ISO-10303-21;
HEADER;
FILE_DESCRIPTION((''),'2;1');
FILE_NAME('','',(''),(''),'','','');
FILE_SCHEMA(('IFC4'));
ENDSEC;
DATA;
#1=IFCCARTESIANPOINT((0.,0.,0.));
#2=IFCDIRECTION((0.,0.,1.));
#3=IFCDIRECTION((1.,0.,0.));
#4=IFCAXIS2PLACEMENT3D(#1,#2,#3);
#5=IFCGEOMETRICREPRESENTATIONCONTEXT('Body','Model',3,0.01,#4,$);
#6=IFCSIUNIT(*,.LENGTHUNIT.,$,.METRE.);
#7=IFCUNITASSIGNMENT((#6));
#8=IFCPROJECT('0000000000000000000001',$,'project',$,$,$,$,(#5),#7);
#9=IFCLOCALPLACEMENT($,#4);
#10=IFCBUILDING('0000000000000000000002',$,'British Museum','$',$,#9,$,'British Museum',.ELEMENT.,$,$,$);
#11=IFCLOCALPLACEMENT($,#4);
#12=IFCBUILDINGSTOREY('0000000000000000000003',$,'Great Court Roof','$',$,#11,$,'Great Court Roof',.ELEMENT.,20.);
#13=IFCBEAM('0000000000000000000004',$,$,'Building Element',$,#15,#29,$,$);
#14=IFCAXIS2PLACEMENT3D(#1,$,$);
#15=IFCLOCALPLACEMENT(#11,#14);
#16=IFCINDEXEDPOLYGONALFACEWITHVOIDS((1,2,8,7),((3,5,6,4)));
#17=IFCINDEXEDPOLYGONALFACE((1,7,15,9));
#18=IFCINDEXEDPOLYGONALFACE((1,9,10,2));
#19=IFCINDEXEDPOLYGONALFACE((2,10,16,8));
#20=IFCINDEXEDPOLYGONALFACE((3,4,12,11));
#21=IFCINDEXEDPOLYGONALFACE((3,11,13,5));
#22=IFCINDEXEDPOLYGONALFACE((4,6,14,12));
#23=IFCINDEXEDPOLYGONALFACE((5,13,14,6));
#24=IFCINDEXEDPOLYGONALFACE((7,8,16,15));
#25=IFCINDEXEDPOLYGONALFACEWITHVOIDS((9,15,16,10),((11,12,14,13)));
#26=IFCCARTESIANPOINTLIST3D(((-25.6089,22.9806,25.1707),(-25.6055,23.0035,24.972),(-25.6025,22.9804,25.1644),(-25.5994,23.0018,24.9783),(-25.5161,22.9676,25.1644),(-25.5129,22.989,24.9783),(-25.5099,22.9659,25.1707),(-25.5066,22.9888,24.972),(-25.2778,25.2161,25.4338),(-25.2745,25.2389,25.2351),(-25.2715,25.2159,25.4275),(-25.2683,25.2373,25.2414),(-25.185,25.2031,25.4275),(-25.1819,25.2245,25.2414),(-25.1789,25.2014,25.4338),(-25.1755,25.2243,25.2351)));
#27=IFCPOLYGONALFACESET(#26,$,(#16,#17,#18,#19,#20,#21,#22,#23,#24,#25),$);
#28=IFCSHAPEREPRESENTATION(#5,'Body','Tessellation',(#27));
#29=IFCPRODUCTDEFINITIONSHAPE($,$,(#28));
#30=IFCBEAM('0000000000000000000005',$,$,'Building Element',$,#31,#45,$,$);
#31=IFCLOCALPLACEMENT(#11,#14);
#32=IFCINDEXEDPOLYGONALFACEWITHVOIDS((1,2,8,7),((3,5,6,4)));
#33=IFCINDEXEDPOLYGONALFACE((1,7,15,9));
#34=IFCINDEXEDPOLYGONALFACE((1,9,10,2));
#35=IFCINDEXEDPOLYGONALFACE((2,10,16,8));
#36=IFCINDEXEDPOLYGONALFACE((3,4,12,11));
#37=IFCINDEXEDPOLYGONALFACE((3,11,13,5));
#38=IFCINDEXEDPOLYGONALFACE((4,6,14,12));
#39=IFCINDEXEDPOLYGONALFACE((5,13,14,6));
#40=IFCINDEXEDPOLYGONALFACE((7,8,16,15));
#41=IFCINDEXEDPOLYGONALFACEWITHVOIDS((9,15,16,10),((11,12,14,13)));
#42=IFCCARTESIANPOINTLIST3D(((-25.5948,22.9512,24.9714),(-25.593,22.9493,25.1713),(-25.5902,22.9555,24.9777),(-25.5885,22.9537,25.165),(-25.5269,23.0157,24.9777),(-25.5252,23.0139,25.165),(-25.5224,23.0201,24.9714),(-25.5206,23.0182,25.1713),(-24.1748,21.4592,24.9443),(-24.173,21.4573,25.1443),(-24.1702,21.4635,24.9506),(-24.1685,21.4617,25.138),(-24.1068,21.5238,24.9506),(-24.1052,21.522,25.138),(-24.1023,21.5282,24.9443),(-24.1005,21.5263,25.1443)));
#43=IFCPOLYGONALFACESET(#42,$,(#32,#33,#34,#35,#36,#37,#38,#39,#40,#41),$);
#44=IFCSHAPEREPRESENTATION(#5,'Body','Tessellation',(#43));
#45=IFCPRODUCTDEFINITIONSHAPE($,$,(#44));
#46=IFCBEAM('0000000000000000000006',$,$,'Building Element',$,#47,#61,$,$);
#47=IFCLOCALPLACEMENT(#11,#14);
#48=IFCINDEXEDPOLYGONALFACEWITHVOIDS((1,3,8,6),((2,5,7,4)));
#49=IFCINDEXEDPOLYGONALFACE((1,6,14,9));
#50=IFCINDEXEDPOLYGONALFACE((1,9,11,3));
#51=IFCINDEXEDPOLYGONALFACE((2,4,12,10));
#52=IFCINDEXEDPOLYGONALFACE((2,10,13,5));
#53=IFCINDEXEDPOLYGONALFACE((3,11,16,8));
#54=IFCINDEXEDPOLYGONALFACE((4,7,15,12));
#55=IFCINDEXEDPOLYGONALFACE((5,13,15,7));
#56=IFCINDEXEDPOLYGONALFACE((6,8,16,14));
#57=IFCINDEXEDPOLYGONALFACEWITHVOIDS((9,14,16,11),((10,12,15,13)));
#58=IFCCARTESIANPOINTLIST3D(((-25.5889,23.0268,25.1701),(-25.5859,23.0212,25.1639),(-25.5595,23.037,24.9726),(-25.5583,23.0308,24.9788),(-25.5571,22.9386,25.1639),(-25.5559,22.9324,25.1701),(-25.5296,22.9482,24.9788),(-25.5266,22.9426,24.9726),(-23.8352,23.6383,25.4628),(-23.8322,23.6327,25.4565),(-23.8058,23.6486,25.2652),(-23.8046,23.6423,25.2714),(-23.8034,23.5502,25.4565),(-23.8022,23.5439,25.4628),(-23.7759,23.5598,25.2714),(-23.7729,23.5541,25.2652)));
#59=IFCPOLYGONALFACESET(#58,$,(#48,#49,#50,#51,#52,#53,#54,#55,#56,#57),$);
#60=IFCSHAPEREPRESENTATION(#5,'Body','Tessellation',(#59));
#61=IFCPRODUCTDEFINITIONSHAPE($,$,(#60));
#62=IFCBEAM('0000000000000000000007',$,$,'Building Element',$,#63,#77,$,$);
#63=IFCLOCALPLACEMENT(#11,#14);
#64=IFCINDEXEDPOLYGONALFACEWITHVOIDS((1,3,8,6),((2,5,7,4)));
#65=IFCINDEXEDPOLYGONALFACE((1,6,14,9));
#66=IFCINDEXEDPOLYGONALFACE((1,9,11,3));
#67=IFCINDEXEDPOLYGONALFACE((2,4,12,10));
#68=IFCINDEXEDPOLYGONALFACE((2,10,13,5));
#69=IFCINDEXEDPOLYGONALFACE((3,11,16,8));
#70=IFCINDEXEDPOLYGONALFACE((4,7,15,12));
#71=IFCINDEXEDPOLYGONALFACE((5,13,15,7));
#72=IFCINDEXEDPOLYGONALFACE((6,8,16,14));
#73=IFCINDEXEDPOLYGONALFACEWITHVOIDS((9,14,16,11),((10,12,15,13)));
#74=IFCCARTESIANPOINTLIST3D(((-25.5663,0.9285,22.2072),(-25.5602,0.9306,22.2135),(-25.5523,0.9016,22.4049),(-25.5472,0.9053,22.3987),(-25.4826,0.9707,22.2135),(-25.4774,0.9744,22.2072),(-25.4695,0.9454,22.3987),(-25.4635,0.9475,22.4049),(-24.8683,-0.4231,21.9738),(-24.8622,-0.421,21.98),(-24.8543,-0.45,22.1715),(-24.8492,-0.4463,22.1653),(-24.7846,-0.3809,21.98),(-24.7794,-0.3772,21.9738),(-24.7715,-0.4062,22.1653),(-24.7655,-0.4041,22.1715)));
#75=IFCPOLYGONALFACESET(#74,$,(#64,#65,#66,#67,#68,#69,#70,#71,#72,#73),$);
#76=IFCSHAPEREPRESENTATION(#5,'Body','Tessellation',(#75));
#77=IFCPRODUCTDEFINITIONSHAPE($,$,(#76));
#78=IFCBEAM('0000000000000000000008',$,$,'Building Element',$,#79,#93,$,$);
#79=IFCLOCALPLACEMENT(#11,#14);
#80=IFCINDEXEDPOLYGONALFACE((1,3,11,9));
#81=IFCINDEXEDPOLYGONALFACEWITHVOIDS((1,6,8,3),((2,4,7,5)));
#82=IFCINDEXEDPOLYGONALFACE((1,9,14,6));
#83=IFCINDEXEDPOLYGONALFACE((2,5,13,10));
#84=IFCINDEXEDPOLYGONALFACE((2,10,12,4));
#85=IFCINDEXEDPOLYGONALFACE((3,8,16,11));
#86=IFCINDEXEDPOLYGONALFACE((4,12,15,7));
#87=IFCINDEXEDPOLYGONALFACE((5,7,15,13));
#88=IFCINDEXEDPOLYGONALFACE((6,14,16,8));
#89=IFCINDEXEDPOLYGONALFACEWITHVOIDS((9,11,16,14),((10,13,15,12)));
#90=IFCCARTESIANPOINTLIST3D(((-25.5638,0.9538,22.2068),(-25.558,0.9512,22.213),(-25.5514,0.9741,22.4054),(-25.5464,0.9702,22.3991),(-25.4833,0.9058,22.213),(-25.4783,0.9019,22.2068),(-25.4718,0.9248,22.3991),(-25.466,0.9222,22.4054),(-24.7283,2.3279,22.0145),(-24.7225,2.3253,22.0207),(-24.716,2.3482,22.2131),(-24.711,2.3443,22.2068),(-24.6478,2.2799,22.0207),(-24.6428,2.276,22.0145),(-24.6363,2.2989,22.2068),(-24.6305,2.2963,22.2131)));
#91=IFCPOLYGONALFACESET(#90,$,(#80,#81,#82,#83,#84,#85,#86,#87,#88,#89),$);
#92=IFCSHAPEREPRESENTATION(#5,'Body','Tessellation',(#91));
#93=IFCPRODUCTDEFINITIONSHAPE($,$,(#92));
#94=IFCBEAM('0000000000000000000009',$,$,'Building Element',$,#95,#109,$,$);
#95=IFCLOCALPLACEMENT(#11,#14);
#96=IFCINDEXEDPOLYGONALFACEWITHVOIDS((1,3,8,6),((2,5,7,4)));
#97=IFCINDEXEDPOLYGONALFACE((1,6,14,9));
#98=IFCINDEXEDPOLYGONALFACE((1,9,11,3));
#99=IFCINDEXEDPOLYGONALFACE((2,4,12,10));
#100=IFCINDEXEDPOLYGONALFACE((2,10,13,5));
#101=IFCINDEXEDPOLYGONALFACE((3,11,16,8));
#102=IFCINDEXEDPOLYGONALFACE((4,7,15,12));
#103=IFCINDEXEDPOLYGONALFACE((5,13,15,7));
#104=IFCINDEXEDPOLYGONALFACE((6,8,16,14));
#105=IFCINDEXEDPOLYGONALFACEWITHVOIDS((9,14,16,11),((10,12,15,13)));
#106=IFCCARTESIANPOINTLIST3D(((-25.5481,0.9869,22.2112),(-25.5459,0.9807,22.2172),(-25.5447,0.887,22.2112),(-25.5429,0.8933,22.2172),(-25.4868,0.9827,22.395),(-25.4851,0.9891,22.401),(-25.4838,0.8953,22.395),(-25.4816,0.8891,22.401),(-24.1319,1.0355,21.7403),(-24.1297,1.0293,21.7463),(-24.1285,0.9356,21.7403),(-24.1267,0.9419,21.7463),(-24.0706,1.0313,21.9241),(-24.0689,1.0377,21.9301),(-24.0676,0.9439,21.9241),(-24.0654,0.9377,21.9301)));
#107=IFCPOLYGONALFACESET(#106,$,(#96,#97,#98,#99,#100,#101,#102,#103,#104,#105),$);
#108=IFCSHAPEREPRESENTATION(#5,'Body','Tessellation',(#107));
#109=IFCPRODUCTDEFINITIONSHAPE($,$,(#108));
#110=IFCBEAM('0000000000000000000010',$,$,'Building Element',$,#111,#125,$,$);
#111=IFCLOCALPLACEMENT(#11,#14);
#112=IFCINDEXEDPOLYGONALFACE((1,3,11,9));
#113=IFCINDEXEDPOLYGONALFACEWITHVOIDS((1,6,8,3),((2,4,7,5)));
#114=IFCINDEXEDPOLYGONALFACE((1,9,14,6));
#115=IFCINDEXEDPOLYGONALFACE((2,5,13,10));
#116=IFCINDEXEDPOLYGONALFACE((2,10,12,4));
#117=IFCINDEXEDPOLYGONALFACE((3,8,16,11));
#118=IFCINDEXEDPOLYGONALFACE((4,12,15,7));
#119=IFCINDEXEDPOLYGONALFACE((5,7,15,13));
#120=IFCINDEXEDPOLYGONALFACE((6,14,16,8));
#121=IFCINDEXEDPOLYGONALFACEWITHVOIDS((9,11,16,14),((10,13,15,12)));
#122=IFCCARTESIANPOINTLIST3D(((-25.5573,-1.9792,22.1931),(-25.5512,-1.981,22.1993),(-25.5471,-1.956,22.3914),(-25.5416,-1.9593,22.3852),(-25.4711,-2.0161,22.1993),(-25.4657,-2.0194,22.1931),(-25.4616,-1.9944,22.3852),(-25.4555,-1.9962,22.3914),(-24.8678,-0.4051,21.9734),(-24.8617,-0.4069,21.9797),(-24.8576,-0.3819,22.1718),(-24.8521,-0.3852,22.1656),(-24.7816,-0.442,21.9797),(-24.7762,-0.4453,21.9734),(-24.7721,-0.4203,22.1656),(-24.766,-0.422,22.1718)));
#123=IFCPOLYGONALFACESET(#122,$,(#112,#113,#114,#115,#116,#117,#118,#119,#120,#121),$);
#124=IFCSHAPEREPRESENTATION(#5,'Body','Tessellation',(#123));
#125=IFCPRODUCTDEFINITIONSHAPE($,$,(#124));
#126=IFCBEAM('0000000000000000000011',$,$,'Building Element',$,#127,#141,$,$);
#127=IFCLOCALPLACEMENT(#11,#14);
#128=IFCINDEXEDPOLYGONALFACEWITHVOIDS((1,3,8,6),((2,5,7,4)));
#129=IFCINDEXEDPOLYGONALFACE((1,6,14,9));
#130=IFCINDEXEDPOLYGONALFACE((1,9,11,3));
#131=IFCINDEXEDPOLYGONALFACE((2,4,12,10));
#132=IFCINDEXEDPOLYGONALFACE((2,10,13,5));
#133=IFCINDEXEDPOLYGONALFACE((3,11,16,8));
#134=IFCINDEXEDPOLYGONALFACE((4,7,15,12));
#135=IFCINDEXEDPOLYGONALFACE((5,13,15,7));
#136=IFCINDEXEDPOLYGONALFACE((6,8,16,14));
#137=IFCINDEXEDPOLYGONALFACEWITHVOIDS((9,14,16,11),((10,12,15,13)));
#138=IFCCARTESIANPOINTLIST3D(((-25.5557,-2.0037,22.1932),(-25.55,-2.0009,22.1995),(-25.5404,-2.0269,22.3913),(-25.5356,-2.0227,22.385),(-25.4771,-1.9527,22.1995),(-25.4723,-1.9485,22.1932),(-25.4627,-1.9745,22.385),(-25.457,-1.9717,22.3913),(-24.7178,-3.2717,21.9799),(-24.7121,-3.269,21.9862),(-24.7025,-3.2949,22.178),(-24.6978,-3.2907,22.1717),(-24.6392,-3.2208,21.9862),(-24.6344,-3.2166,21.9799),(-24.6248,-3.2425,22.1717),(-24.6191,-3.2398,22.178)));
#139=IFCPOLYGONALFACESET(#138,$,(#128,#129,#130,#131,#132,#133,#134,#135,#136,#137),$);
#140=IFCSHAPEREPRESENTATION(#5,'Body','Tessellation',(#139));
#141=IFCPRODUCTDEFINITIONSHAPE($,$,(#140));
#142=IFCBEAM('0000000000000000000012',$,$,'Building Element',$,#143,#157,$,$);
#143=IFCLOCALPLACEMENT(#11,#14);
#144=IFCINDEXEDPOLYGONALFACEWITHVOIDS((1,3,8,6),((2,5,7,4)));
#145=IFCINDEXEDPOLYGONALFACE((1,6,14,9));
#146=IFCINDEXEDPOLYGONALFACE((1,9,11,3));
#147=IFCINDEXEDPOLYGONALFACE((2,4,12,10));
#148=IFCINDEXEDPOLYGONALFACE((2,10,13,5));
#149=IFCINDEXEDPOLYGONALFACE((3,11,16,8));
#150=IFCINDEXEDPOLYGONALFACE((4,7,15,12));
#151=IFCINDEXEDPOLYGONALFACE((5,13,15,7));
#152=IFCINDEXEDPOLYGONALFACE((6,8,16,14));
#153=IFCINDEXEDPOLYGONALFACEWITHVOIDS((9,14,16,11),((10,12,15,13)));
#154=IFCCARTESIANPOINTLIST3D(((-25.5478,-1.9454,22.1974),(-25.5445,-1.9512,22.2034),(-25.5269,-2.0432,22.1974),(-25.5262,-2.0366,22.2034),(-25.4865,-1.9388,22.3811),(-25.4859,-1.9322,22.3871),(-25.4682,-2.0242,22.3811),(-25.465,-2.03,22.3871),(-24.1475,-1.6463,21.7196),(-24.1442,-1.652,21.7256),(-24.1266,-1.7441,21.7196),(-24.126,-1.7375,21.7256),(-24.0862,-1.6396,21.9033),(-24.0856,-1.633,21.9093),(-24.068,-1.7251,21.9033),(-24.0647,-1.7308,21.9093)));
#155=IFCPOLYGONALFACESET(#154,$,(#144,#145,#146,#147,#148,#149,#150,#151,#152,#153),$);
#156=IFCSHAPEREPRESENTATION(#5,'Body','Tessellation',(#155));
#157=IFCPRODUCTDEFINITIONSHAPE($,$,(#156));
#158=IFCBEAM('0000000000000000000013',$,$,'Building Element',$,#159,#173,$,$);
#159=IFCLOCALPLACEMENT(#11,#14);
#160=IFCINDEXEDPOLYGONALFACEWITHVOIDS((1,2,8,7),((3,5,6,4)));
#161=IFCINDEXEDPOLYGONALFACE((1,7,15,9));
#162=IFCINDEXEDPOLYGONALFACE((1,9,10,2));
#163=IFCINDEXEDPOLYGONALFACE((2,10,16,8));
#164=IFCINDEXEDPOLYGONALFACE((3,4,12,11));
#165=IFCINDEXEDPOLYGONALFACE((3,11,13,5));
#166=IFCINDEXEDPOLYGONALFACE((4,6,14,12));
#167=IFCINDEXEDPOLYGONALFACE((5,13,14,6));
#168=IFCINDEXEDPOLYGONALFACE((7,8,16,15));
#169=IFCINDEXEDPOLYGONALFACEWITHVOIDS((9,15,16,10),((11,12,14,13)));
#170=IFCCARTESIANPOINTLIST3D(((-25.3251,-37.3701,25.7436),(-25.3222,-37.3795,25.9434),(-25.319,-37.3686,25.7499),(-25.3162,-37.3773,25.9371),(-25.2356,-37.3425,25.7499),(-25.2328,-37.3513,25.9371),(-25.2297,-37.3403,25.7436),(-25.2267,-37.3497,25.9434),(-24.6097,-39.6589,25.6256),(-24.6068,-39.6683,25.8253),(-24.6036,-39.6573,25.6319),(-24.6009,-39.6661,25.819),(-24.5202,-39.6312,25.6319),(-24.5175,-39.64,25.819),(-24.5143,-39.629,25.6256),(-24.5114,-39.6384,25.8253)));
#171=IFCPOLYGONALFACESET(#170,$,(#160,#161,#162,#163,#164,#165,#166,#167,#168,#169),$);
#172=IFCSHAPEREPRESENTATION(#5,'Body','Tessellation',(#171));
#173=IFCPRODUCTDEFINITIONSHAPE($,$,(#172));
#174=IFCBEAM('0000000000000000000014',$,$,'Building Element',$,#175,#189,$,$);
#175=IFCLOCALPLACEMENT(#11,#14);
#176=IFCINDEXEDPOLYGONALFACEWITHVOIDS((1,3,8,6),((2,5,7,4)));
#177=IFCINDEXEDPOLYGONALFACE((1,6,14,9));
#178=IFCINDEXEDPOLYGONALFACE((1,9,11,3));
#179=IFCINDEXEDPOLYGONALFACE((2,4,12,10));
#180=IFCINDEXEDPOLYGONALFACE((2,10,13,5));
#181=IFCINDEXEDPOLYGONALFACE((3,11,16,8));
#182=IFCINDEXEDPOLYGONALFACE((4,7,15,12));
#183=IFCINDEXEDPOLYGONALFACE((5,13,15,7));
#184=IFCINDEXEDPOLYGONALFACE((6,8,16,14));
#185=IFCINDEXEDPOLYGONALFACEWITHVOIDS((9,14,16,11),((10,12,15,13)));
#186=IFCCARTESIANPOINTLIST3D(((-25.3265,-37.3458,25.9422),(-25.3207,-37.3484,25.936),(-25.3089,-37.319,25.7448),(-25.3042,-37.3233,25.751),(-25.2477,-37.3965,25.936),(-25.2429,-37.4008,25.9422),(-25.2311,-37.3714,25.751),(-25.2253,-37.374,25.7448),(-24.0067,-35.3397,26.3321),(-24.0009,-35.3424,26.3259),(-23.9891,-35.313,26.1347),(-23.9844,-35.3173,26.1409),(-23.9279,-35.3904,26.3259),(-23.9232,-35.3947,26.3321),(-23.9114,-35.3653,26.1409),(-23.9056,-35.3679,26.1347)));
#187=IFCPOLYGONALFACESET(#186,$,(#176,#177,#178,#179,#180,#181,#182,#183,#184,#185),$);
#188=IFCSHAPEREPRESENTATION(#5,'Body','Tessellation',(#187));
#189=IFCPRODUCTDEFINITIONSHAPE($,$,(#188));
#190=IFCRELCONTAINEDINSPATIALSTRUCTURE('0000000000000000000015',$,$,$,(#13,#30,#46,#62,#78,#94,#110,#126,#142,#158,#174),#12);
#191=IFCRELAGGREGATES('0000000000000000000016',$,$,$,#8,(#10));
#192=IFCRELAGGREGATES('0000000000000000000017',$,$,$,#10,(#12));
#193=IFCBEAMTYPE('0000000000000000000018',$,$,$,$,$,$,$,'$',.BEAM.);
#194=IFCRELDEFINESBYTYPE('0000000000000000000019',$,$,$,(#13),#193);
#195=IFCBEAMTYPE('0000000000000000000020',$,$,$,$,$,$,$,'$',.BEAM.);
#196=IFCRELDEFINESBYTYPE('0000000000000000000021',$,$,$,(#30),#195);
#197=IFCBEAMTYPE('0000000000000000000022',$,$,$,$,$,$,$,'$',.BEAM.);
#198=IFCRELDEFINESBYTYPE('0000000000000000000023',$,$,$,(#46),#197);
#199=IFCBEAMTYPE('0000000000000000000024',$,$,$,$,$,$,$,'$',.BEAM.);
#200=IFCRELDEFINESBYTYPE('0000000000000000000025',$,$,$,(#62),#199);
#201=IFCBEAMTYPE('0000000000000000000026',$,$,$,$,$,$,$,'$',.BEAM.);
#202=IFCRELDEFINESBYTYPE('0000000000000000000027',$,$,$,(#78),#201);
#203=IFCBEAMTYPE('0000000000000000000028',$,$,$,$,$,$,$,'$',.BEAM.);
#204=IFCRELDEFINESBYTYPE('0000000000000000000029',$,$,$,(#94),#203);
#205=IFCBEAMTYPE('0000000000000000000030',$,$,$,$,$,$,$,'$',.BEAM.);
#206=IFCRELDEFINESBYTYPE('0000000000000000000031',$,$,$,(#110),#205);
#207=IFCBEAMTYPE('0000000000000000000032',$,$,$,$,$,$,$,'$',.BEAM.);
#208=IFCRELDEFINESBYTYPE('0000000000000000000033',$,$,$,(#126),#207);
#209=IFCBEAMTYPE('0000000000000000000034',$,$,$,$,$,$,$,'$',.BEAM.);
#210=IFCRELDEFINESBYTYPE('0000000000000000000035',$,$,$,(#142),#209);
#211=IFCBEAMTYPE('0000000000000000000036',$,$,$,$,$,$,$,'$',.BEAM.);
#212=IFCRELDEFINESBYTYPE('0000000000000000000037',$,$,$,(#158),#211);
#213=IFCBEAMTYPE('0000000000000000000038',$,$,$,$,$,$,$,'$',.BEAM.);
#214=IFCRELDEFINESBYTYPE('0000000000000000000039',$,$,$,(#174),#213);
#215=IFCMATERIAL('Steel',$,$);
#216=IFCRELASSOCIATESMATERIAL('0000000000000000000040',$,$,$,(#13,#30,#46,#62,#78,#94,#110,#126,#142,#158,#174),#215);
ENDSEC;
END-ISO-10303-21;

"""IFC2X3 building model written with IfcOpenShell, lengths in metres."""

from ifc_helpers import new_model, si_unit, frame, origin_with_axes, origin_2d, place, context, project, spatial, hollow_rectangle, extrude, material, type_object, element, save


model = new_model("IFC2X3")

# Units and contexts
model_context = context("Model", 3, precision=0.01, world=origin_with_axes(), identifier="Body")
ifc_project = project(units=[si_unit("LENGTHUNIT", "METRE")], contexts=[model_context])

# Building, storey
building_placement = place(None, origin_with_axes())
building = spatial("IfcBuilding", under=ifc_project, at=building_placement, Name="British Museum", Description="$", LongName="British Museum", CompositionType="ELEMENT")
storey_placement = place(None, origin_with_axes())
storey = spatial("IfcBuildingStorey", under=building, at=storey_placement, Name="Great Court Roof", Description="$", LongName="Great Court Roof", CompositionType="ELEMENT", Elevation=20.0)

# Beams
ifc_material = material(Name="Steel")
beam_type_1 = type_object("IfcBeamType", ElementType="$", PredefinedType="BEAM")
beam_1_placement = place(None, origin_with_axes())
element("IfcBeam", 1, at=beam_1_placement, inside=storey, type_object=beam_type_1, material=ifc_material, Description="Building Element", context=model_context, shape_type="SweptSolid", body=[
    extrude(hollow_rectangle(XDim=0.1, YDim=0.2, WallThickness=0.0063, InnerFilletRadius=-0.0063, OuterFilletRadius=0.0, at=origin_2d()), frame((-25.5577, 22.9847, 25.0714), z_axis=(0.145499, 0.982577, 0.115638), x_axis=(-0.989213, 0.146481, 0.0)), (0.0, 0.0, 1.0), 2.2751),
])
beam_type_2 = type_object("IfcBeamType", ElementType="$", PredefinedType="BEAM")
beam_2_placement = place(None, origin_with_axes())
element("IfcBeam", 2, at=beam_2_placement, inside=storey, type_object=beam_type_2, material=ifc_material, Description="Building Element", context=model_context, shape_type="SweptSolid", body=[
    extrude(hollow_rectangle(XDim=0.1, YDim=0.2, WallThickness=0.0063, InnerFilletRadius=-0.0063, OuterFilletRadius=0.0, at=origin_2d()), frame((-25.5577, 22.9847, 25.0714), z_axis=(0.689378, -0.724283, -0.013142), x_axis=(0.724345, 0.689437, 0.0)), (0.0, 0.0, 1.0), 2.0599),
])
beam_type_3 = type_object("IfcBeamType", ElementType="$", PredefinedType="BEAM")
beam_3_placement = place(None, origin_with_axes())
element("IfcBeam", 3, at=beam_3_placement, inside=storey, type_object=beam_type_3, material=ifc_material, Description="Building Element", context=model_context, shape_type="SweptSolid", body=[
    extrude(hollow_rectangle(XDim=0.1, YDim=0.2, WallThickness=0.0063, InnerFilletRadius=-0.0063, OuterFilletRadius=0.0, at=origin_2d()), frame((-25.5577, 22.9847, 25.0714), z_axis=(0.932733, 0.325249, 0.155634), x_axis=(-0.329261, 0.944239, 0.0)), (0.0, 0.0, 1.0), 1.8802),
])
beam_type_4 = type_object("IfcBeamType", ElementType="$", PredefinedType="BEAM")
beam_4_placement = place(None, origin_with_axes())
element("IfcBeam", 4, at=beam_4_placement, inside=storey, type_object=beam_type_4, material=ifc_material, Description="Building Element", context=model_context, shape_type="SweptSolid", body=[
    extrude(hollow_rectangle(XDim=0.1, YDim=0.2, WallThickness=0.0063, InnerFilletRadius=-0.0063, OuterFilletRadius=0.0, at=origin_2d()), frame((-25.5149, 0.938, 22.3061), z_axis=(0.453539, -0.878235, -0.151676), x_axis=(0.888515, 0.458848, 0.0)), (0.0, 0.0, 1.0), 1.539),
])
beam_type_5 = type_object("IfcBeamType", ElementType="$", PredefinedType="BEAM")
beam_5_placement = place(None, origin_with_axes())
element("IfcBeam", 5, at=beam_5_placement, inside=storey, type_object=beam_type_5, material=ifc_material, Description="Building Element", context=model_context, shape_type="SweptSolid", body=[
    extrude(hollow_rectangle(XDim=0.1, YDim=0.2, WallThickness=0.0063, InnerFilletRadius=-0.0063, OuterFilletRadius=0.0, at=origin_2d()), frame((-25.5149, 0.938, 22.3061), z_axis=(0.515847, 0.848412, -0.118739), x_axis=(-0.854457, 0.519523, 0.0)), (0.0, 0.0, 1.0), 1.6196),
])
beam_type_6 = type_object("IfcBeamType", ElementType="$", PredefinedType="BEAM")
beam_6_placement = place(None, origin_with_axes())
element("IfcBeam", 6, at=beam_6_placement, inside=storey, type_object=beam_type_6, material=ifc_material, Description="Building Element", context=model_context, shape_type="SweptSolid", body=[
    extrude(hollow_rectangle(XDim=0.1, YDim=0.2, WallThickness=0.0063, InnerFilletRadius=-0.0063, OuterFilletRadius=0.0, at=origin_2d()), frame((-25.5149, 0.938, 22.3061), z_axis=(0.948419, 0.032547, -0.315343), x_axis=(-0.034297, 0.999412, 0.0)), (0.0, 0.0, 1.0), 1.4932),
])
beam_type_7 = type_object("IfcBeamType", ElementType="$", PredefinedType="BEAM")
beam_7_placement = place(None, origin_with_axes())
element("IfcBeam", 7, at=beam_7_placement, inside=storey, type_object=beam_type_7, material=ifc_material, Description="Building Element", context=model_context, shape_type="SweptSolid", body=[
    extrude(hollow_rectangle(XDim=0.1, YDim=0.2, WallThickness=0.0063, InnerFilletRadius=-0.0063, OuterFilletRadius=0.0, at=origin_2d()), frame((-25.5064, -1.9877, 22.2922), z_axis=(0.397984, 0.908593, -0.12676), x_axis=(-0.915982, 0.40122, 0.0)), (0.0, 0.0, 1.0), 1.7325),
])
beam_type_8 = type_object("IfcBeamType", ElementType="$", PredefinedType="BEAM")
beam_8_placement = place(None, origin_with_axes())
element("IfcBeam", 8, at=beam_8_placement, inside=storey, type_object=beam_type_8, material=ifc_material, Description="Building Element", context=model_context, shape_type="SweptSolid", body=[
    extrude(hollow_rectangle(XDim=0.1, YDim=0.2, WallThickness=0.0063, InnerFilletRadius=-0.0063, OuterFilletRadius=0.0, at=origin_2d()), frame((-25.5064, -1.9877, 22.2922), z_axis=(0.545944, -0.826215, -0.138976), x_axis=(0.834311, 0.551293, 0.0)), (0.0, 0.0, 1.0), 1.5348),
])
beam_type_9 = type_object("IfcBeamType", ElementType="$", PredefinedType="BEAM")
beam_9_placement = place(None, origin_with_axes())
element("IfcBeam", 9, at=beam_9_placement, inside=storey, type_object=beam_type_9, material=ifc_material, Description="Building Element", context=model_context, shape_type="SweptSolid", body=[
    extrude(hollow_rectangle(XDim=0.1, YDim=0.2, WallThickness=0.0063, InnerFilletRadius=-0.0063, OuterFilletRadius=0.0, at=origin_2d()), frame((-25.5064, -1.9877, 22.2922), z_axis=(0.927647, 0.198181, -0.316535), x_axis=(-0.208924, 0.977932, 0.0)), (0.0, 0.0, 1.0), 1.5095),
])
beam_type_10 = type_object("IfcBeamType", ElementType="$", PredefinedType="BEAM")
beam_10_placement = place(None, origin_with_axes())
element("IfcBeam", 10, at=beam_10_placement, inside=storey, type_object=beam_type_10, material=ifc_material, Description="Building Element", context=model_context, shape_type="SweptSolid", body=[
    extrude(hollow_rectangle(XDim=0.1, YDim=0.2, WallThickness=0.0063, InnerFilletRadius=-0.0063, OuterFilletRadius=0.0, at=origin_2d()), frame((-25.2759, -37.3599, 25.8435), z_axis=(0.297963, -0.95331, -0.049181), x_axis=(0.954465, 0.298324, 0.0)), (0.0, 0.0, 1.0), 2.4008),
])
beam_type_11 = type_object("IfcBeamType", ElementType="$", PredefinedType="BEAM")
beam_11_placement = place(None, origin_with_axes())
element("IfcBeam", 11, at=beam_11_placement, inside=storey, type_object=beam_type_11, material=ifc_material, Description="Building Element", context=model_context, shape_type="SweptSolid", body=[
    extrude(hollow_rectangle(XDim=0.1, YDim=0.2, WallThickness=0.0063, InnerFilletRadius=-0.0063, OuterFilletRadius=0.0, at=origin_2d()), frame((-25.2759, -37.3599, 25.8435), z_axis=(0.542503, 0.824624, 0.16027), x_axis=(-0.835423, 0.549608, 0.0)), (0.0, 0.0, 1.0), 2.4327),
])

save(model, "model.ifc")
